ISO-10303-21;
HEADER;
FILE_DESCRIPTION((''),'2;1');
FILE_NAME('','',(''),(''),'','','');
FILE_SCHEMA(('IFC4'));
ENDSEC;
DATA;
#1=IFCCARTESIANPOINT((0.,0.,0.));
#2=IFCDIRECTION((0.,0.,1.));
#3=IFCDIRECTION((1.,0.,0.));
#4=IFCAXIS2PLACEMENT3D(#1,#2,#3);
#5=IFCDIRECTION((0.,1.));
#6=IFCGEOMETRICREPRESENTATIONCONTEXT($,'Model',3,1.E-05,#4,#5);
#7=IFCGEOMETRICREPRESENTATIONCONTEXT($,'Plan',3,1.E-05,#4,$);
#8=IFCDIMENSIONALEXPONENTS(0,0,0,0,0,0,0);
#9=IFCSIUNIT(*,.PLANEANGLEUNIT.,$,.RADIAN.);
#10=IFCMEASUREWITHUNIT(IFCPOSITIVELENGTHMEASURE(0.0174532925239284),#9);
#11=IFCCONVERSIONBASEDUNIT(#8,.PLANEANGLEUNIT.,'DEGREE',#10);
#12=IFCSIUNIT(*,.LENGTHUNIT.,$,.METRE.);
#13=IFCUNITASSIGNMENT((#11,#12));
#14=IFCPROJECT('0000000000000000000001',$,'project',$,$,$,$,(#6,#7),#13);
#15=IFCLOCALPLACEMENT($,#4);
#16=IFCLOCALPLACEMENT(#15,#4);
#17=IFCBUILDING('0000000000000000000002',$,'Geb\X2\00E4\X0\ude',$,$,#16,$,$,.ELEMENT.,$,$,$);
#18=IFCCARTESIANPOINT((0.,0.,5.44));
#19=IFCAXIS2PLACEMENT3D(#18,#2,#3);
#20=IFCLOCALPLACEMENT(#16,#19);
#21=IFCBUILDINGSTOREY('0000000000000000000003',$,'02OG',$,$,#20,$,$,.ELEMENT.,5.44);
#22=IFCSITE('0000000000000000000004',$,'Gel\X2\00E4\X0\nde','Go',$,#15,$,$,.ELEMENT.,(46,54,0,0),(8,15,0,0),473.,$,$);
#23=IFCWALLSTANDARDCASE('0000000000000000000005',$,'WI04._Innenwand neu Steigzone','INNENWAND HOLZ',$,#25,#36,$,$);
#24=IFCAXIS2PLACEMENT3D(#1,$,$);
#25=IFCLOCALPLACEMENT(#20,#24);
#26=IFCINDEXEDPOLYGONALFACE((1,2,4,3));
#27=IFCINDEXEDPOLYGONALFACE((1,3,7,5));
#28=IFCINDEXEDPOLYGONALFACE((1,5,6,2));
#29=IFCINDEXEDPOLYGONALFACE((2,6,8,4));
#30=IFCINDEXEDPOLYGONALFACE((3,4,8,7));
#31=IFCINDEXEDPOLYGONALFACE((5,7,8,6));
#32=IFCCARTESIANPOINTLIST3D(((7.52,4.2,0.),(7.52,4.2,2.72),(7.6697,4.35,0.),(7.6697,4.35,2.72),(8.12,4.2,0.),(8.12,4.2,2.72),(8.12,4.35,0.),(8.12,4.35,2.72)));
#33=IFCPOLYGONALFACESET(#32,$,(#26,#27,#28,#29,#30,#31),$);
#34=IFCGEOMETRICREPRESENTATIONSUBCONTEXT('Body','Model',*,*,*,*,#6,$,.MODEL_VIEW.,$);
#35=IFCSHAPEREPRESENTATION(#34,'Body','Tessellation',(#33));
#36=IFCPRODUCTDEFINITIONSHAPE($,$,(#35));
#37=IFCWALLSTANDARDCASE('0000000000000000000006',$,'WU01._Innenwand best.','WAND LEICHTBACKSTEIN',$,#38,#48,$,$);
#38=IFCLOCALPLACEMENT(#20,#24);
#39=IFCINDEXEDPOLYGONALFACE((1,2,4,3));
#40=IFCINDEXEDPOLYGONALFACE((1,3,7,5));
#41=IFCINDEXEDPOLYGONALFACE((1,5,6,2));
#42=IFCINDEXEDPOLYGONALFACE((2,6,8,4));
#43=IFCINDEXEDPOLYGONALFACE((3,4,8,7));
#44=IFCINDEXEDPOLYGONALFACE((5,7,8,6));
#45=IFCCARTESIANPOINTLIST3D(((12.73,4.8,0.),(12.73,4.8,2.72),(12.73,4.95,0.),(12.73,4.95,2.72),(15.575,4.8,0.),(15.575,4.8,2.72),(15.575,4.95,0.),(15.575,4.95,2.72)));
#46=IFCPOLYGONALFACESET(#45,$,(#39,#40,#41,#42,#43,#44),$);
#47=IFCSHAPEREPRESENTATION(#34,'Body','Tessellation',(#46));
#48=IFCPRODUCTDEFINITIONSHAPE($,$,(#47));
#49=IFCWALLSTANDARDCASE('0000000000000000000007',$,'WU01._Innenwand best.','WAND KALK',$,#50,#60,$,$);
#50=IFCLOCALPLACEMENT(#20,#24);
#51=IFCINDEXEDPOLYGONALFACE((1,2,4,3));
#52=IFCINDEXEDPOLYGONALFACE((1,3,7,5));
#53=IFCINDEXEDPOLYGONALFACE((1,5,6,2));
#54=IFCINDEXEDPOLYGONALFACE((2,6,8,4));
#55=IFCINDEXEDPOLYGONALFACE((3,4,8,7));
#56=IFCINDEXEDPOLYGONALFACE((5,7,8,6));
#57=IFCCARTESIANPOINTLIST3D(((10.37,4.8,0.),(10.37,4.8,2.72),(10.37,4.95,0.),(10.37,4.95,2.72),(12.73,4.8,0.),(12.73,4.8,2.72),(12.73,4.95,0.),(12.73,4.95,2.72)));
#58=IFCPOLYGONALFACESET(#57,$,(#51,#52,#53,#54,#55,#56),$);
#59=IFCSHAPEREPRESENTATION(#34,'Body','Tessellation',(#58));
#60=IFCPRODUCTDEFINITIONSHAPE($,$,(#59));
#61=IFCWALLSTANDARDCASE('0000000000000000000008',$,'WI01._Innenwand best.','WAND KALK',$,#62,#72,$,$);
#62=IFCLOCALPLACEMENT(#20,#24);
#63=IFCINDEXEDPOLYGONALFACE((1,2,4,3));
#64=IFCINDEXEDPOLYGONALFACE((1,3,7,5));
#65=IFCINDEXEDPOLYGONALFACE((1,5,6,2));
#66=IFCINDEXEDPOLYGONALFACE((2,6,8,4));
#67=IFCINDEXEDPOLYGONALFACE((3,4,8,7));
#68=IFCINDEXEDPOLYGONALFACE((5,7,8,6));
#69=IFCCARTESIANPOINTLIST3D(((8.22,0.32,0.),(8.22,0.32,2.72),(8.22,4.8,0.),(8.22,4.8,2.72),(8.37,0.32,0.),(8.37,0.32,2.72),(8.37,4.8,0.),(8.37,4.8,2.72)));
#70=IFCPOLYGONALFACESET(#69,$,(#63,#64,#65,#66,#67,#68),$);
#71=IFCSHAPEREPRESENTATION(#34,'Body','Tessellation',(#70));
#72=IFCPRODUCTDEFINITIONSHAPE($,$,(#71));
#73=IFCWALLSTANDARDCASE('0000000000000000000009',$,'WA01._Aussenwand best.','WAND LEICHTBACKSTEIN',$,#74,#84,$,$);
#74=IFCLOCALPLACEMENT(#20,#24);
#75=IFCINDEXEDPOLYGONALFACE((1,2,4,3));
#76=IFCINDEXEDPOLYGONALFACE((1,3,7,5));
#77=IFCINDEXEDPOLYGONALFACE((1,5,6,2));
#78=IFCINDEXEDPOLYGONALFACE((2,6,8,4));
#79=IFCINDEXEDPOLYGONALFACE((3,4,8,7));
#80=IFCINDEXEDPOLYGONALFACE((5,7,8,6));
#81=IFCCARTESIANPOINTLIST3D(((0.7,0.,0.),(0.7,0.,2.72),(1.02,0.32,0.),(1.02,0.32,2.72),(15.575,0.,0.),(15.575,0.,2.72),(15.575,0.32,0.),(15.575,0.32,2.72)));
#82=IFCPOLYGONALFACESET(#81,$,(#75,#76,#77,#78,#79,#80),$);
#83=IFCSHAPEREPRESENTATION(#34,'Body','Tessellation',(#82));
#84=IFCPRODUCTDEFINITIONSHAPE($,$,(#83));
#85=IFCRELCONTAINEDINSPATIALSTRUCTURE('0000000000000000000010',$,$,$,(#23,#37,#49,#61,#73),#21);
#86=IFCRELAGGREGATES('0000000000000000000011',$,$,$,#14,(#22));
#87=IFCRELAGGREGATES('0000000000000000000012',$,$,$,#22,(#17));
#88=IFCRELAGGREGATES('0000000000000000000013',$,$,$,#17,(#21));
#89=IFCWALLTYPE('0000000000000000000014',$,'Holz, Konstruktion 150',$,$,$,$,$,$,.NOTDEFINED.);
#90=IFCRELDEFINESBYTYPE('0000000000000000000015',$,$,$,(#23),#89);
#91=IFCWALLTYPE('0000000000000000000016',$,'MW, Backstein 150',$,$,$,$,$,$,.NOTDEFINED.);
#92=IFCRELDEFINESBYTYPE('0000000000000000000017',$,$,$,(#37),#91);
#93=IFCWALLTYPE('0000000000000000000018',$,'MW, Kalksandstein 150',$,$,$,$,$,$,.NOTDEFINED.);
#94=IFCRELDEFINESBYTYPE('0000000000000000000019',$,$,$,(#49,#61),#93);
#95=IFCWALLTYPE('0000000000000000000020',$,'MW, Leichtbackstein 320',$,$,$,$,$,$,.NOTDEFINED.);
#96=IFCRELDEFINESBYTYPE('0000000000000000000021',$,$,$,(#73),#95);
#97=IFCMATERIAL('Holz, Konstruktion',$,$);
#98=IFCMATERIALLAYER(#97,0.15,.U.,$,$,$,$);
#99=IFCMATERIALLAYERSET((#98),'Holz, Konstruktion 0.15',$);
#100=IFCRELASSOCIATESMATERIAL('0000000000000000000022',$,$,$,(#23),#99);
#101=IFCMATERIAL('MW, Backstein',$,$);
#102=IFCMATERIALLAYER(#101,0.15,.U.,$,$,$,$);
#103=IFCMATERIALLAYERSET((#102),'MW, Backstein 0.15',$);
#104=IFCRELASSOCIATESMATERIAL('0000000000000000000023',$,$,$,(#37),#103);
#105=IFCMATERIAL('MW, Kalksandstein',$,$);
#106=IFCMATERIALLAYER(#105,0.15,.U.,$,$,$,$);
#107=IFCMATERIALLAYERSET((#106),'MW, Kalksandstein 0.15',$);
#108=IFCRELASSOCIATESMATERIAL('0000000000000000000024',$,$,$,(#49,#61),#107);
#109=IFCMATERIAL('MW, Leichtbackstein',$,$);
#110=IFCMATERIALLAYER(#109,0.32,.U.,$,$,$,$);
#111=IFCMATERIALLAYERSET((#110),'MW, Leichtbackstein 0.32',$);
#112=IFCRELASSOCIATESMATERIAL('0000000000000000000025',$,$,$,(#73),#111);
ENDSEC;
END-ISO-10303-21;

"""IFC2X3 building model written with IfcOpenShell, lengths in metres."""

from ifc_helpers import new_model, entity, si_unit, converted_unit, direction, frame, origin_with_axes, place, context, subcontext, project, spatial, polyline, outline, extrude, material, layer, layer_set, layer_usage, type_object, element, save


model = new_model("IFC2X3")

# Units and contexts
model_context = context("Model", 3, precision=1e-05, world=origin_with_axes(), true_north=direction((0.0, 1.0)))
plan_context = context("Plan", 3, precision=1e-05, world=origin_with_axes())
body_context = subcontext(model_context, "Body", "Model", "MODEL_VIEW")
ifc_project = project(units=[converted_unit("PLANEANGLEUNIT", "DEGREE", entity("IfcPositiveLengthMeasure", 0.0174532925239284), si_unit("PLANEANGLEUNIT", "RADIAN"), dimensions=[0, 0, 0, 0, 0, 0, 0]), si_unit("LENGTHUNIT", "METRE")], contexts=[model_context, plan_context])

# Site, building, storey
site_placement = place(None, origin_with_axes())
site = spatial("IfcSite", under=ifc_project, at=site_placement, Name="Gelände", Description="Go", CompositionType="ELEMENT", RefLatitude=(46, 54, 0, 0), RefLongitude=(8, 15, 0, 0), RefElevation=473.0)
building_placement = place(site_placement, origin_with_axes())
building = spatial("IfcBuilding", under=site, at=building_placement, Name="Gebäude", CompositionType="ELEMENT")
storey_placement = place(building_placement, frame((0.0, 0.0, 5.44), z_axis=(0.0, 0.0, 1.0), x_axis=(1.0, 0.0, 0.0)))
storey = spatial("IfcBuildingStorey", under=building, at=storey_placement, Name="02OG", CompositionType="ELEMENT", Elevation=5.44)

# Shared definitions
ifc_material_1 = material(Name="Holz, Konstruktion")

# Walls
ifc_layer_1 = layer(ifc_material_1, 0.15, ventilated="UNKNOWN")
ifc_layer_set_1 = layer_set([ifc_layer_1], Name="Holz, Konstruktion 0.15")
wall_type_1 = type_object("IfcWallType", Name="Holz, Konstruktion 150", PredefinedType="NOTDEFINED")
ifc_layer_usage_1 = layer_usage(ifc_layer_set_1, "AXIS2", "NEGATIVE", 0.0)
wall_1_placement = place(storey_placement, frame((8.12, 4.2, 0.0), z_axis=(0.0, 0.0, 1.0), x_axis=(-1.0, 0.0, 0.0)))
element("IfcWallStandardCase", 1, at=wall_1_placement, inside=storey, type_object=wall_type_1, material=ifc_layer_usage_1, Name="WI04._Innenwand neu Steigzone", Description="INNENWAND HOLZ", context=body_context, shape_type="SweptSolid", body=[
    extrude(outline(polyline([(0.0, -0.15), (0.4503, -0.15), (0.6, 0.0), (0.0, 0.0), (0.0, -0.15)])), origin_with_axes(), (0.0, 0.0, 1.0), 2.72),
])
ifc_material_2 = material(Name="MW, Backstein")
ifc_layer_2 = layer(ifc_material_2, 0.15, ventilated="UNKNOWN")
ifc_layer_set_2 = layer_set([ifc_layer_2], Name="MW, Backstein 0.15")
ifc_layer_usage_2 = layer_usage(ifc_layer_set_2, "AXIS2", "POSITIVE", -0.15)
wall_type_2 = type_object("IfcWallType", Name="MW, Backstein 150", PredefinedType="NOTDEFINED")
wall_2_placement = place(storey_placement, frame((12.73, 4.95, 0.0), z_axis=(0.0, 0.0, 1.0), x_axis=(1.0, 0.0, 0.0)))
element("IfcWallStandardCase", 2, at=wall_2_placement, inside=storey, type_object=wall_type_2, material=ifc_layer_usage_2, Name="WU01._Innenwand best.", Description="WAND LEICHTBACKSTEIN", context=body_context, shape_type="SweptSolid", body=[
    extrude(outline(polyline([(0.0, -0.15), (2.845, -0.15), (2.845, 0.0), (0.0, 0.0), (0.0, -0.15)])), origin_with_axes(), (0.0, 0.0, 1.0), 2.72),
])
ifc_material_3 = material(Name="MW, Kalksandstein")
ifc_layer_3 = layer(ifc_material_3, 0.15, ventilated="UNKNOWN")
ifc_layer_set_3 = layer_set([ifc_layer_3], Name="MW, Kalksandstein 0.15")
ifc_layer_usage_3 = layer_usage(ifc_layer_set_3, "AXIS2", "POSITIVE", -0.15)
wall_type_3 = type_object("IfcWallType", Name="MW, Kalksandstein 150", PredefinedType="NOTDEFINED")
wall_3_placement = place(storey_placement, frame((10.37, 4.95, 0.0), z_axis=(0.0, 0.0, 1.0), x_axis=(1.0, 0.0, 0.0)))
element("IfcWallStandardCase", 3, at=wall_3_placement, inside=storey, type_object=wall_type_3, material=ifc_layer_usage_3, Name="WU01._Innenwand best.", Description="WAND KALK", context=body_context, shape_type="SweptSolid", body=[
    extrude(outline(polyline([(0.0, -0.15), (2.36, -0.15), (2.36, 0.0), (0.0, 0.0), (0.0, -0.15)])), origin_with_axes(), (0.0, 0.0, 1.0), 2.72),
])
ifc_layer_usage_4 = layer_usage(ifc_layer_set_3, "AXIS2", "NEGATIVE", 0.0)
wall_4_placement = place(storey_placement, frame((8.22, 0.32, 0.0), z_axis=(0.0, 0.0, 1.0), x_axis=(0.0, 1.0, 0.0)))
element("IfcWallStandardCase", 4, at=wall_4_placement, inside=storey, type_object=wall_type_3, material=ifc_layer_usage_4, Name="WI01._Innenwand best.", Description="WAND KALK", context=body_context, shape_type="SweptSolid", body=[
    extrude(outline(polyline([(0.0, -0.15), (4.48, -0.15), (4.48, 0.0), (0.0, 0.0), (0.0, -0.15)])), origin_with_axes(), (0.0, 0.0, 1.0), 2.72),
])
ifc_material_4 = material(Name="MW, Leichtbackstein")
ifc_layer_4 = layer(ifc_material_4, 0.32, ventilated="UNKNOWN")
ifc_layer_set_4 = layer_set([ifc_layer_4], Name="MW, Leichtbackstein 0.32")
ifc_layer_usage_5 = layer_usage(ifc_layer_set_4, "AXIS2", "POSITIVE", -0.32)
wall_type_4 = type_object("IfcWallType", Name="MW, Leichtbackstein 320", PredefinedType="NOTDEFINED")
wall_5_placement = place(storey_placement, frame((1.02, 0.32, 0.0), z_axis=(0.0, 0.0, 1.0), x_axis=(1.0, 0.0, 0.0)))
element("IfcWallStandardCase", 5, at=wall_5_placement, inside=storey, type_object=wall_type_4, material=ifc_layer_usage_5, Name="WA01._Aussenwand best.", Description="WAND LEICHTBACKSTEIN", context=body_context, shape_type="SweptSolid", body=[
    extrude(outline(polyline([(-0.32, -0.32), (14.555, -0.32), (14.555, 0.0), (0.0, 0.0), (-0.32, -0.32)])), origin_with_axes(), (0.0, 0.0, 1.0), 2.72),
])

save(model, "model.ifc")
